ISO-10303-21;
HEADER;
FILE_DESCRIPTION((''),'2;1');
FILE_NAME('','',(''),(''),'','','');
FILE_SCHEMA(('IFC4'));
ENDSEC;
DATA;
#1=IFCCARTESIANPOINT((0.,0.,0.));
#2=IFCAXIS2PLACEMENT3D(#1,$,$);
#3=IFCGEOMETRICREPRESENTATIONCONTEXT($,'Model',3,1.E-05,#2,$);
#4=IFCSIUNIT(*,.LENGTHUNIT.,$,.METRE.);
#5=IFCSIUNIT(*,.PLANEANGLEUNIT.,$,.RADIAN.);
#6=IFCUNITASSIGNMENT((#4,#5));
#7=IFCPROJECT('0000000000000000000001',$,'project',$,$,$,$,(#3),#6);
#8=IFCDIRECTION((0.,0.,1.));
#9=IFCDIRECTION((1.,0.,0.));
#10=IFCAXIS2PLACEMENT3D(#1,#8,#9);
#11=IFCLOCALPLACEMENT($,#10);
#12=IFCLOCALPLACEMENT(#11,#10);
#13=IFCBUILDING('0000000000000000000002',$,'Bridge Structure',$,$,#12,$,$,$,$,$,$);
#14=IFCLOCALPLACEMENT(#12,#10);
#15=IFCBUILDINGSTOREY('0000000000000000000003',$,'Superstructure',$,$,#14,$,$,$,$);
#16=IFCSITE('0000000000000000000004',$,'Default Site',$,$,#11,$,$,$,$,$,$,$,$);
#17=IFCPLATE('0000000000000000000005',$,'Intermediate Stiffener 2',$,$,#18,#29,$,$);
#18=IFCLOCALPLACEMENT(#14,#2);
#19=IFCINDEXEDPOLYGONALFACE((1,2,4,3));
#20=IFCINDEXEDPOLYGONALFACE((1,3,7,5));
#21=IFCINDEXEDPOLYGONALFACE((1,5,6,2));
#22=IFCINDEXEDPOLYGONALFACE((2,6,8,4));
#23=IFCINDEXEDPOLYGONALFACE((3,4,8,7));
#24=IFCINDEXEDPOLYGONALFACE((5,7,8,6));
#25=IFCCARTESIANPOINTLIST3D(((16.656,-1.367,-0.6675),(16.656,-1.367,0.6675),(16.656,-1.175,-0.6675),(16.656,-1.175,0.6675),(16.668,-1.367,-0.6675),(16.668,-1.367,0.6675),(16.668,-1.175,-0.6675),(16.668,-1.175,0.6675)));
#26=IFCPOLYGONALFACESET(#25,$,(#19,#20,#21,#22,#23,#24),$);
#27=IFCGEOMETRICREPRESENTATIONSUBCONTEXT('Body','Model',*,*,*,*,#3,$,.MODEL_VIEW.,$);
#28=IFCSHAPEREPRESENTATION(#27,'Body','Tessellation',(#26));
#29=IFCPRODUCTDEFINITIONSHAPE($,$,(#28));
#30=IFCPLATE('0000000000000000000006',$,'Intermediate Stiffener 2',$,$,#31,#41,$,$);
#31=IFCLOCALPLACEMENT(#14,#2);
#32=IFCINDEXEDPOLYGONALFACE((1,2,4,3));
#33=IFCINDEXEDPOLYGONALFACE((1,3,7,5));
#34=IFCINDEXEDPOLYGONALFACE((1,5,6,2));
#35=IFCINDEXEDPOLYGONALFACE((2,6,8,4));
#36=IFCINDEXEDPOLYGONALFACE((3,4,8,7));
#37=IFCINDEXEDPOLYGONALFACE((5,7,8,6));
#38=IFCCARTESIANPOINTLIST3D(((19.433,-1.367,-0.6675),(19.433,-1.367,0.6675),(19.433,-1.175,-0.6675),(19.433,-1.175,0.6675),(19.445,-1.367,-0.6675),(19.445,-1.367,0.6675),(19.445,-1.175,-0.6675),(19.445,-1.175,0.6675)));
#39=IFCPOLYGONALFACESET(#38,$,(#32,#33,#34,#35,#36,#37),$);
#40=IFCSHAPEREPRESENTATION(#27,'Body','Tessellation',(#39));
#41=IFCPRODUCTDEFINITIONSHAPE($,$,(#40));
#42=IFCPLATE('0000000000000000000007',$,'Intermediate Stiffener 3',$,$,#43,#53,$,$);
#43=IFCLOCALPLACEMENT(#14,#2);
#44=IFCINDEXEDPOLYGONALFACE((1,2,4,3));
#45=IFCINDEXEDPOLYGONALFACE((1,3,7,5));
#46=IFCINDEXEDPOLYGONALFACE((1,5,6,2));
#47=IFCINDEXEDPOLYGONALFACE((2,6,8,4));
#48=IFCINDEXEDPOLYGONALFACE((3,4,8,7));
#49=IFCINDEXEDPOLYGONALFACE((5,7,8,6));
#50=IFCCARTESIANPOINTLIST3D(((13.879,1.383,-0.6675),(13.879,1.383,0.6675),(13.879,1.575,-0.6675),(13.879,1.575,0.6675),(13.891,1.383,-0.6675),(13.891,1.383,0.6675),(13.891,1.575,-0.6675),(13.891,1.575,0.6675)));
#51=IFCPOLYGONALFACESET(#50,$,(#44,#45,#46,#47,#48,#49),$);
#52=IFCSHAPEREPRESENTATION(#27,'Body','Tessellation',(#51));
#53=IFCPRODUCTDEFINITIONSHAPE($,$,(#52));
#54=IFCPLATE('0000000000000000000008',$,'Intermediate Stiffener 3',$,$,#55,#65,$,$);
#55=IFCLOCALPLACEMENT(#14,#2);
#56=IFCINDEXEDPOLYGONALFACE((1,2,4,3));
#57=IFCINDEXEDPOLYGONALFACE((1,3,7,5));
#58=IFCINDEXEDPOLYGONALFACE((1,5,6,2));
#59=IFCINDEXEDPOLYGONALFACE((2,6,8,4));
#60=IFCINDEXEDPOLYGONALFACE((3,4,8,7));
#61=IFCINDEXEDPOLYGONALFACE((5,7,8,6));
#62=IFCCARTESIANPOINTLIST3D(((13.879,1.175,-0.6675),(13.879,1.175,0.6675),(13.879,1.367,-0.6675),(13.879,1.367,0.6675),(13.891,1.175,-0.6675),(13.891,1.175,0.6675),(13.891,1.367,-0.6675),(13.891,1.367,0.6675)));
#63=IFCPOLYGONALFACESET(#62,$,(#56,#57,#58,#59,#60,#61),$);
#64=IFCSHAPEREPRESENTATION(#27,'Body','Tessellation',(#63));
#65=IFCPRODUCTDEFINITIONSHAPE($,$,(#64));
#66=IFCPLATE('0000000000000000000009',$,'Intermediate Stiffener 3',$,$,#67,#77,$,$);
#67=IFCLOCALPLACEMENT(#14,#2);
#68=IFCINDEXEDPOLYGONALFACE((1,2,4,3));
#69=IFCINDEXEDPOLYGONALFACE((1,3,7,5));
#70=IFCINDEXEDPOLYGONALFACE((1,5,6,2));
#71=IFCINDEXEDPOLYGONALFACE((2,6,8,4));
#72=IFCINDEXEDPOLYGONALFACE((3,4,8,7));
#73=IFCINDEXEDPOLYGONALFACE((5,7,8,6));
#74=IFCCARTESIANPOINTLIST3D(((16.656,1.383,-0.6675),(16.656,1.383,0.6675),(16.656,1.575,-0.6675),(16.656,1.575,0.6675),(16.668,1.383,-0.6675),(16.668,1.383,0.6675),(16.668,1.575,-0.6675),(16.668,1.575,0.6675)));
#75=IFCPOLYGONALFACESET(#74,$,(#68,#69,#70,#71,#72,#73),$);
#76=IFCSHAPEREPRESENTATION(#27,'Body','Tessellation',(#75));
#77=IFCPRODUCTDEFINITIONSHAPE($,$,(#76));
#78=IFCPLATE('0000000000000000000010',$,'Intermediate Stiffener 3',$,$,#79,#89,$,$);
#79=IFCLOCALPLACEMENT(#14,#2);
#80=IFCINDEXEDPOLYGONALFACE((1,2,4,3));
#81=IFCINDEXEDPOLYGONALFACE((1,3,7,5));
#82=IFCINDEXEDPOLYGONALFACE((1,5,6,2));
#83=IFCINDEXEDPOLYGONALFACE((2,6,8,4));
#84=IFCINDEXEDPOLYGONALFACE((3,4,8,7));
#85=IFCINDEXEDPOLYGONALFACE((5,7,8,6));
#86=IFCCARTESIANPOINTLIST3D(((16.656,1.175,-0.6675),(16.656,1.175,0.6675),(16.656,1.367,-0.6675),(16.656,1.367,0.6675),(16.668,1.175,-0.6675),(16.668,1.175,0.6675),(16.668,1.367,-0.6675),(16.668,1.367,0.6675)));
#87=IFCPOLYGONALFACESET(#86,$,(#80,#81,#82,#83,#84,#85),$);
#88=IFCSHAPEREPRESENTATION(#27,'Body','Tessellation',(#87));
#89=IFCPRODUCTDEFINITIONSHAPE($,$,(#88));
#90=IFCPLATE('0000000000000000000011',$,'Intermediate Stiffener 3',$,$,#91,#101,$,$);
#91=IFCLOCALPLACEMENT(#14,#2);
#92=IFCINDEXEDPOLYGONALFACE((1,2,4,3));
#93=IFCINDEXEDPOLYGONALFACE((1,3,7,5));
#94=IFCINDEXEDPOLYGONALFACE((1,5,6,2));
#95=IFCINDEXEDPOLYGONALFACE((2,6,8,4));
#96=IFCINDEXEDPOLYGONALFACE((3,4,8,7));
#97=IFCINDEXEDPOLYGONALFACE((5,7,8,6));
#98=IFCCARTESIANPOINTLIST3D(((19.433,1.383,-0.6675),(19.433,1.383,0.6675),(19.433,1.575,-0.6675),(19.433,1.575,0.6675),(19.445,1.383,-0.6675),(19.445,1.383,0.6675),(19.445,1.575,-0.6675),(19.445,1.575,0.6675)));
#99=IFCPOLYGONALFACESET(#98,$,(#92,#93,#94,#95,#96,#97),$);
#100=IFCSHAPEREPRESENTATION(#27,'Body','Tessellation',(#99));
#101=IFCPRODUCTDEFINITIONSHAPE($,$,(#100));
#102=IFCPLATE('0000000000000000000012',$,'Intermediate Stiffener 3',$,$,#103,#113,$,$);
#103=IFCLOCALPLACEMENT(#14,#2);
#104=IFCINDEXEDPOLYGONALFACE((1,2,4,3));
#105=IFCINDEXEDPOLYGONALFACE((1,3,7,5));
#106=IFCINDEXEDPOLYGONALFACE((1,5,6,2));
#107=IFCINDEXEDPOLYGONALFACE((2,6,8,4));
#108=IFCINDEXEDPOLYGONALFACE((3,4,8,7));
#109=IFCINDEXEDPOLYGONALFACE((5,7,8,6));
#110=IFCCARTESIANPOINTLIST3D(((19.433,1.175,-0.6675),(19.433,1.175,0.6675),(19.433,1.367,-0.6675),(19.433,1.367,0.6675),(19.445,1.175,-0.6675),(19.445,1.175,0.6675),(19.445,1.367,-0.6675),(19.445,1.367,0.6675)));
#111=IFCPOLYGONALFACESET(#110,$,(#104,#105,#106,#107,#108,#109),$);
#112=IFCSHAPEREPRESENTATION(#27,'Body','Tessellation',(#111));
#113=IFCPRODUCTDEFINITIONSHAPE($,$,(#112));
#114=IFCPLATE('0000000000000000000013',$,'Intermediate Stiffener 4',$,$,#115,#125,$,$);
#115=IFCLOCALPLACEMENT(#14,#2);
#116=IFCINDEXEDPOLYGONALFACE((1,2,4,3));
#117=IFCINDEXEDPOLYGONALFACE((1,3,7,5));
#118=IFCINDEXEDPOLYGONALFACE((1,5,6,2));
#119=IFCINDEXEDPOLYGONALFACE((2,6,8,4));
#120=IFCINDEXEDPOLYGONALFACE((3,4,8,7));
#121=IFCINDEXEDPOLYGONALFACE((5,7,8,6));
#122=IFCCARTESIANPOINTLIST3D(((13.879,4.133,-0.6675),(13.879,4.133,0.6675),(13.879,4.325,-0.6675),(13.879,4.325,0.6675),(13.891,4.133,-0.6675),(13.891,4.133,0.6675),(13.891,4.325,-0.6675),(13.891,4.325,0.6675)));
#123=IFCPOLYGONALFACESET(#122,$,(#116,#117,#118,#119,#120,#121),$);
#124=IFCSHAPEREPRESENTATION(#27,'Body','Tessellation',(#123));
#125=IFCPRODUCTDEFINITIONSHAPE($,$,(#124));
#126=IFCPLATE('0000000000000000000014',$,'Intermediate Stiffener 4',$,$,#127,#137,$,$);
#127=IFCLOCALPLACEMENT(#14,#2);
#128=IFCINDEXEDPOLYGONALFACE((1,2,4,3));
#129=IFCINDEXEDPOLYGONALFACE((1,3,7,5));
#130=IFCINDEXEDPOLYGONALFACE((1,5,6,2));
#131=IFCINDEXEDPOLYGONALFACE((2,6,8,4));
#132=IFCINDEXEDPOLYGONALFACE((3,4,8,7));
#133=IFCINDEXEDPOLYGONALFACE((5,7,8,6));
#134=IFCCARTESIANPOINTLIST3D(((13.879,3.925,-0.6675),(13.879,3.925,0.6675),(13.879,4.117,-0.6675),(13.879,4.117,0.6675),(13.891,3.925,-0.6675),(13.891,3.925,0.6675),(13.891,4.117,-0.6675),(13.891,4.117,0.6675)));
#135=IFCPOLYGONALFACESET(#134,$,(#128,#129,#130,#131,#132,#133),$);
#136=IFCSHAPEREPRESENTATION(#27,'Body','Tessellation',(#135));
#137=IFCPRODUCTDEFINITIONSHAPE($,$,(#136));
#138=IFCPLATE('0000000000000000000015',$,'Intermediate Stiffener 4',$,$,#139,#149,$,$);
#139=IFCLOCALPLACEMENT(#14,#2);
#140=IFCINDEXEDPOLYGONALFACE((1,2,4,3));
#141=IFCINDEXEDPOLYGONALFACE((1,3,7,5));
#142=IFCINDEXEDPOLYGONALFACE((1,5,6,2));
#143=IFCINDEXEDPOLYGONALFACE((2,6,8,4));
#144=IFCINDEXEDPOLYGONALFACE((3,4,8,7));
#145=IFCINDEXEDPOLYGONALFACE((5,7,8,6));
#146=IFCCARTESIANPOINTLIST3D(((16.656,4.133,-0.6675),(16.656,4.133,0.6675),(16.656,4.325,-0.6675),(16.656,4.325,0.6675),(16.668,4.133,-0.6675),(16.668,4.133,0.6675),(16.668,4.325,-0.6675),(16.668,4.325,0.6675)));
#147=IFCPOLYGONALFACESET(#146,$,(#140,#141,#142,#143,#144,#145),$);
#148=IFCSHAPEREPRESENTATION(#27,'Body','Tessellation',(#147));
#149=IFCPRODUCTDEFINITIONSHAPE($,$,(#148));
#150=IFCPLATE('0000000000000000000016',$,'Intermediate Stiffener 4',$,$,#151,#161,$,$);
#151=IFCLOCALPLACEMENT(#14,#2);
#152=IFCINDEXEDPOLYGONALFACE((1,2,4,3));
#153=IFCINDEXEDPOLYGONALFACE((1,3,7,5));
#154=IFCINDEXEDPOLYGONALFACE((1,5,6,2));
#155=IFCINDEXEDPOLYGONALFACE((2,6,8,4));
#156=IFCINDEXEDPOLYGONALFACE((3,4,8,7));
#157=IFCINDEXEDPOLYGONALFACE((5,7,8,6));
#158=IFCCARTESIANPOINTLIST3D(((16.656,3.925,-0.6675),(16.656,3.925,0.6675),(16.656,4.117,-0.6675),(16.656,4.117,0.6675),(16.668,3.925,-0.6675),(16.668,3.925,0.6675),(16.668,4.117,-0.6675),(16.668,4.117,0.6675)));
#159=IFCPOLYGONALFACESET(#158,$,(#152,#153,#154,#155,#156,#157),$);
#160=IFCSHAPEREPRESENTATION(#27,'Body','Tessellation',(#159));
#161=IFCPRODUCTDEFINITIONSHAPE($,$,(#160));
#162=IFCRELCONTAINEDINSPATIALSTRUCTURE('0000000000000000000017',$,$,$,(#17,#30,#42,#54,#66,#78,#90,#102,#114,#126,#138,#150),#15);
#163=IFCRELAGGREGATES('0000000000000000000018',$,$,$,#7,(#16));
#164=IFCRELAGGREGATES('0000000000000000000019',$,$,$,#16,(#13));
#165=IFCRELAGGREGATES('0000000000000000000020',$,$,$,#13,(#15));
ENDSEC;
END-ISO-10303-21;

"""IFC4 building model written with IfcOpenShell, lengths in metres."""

from ifc_helpers import new_model, si_unit, frame, origin, origin_with_axes, origin_2d_with_axis, place, context, subcontext, project, spatial, rectangle, extrude, element, save


model = new_model("IFC4")

# Units and contexts
model_context = context("Model", 3, precision=1e-05, world=origin())
body_context = subcontext(model_context, "Body", "Model", "MODEL_VIEW")
ifc_project = project(units=[si_unit("LENGTHUNIT", "METRE"), si_unit("PLANEANGLEUNIT", "RADIAN")], contexts=[model_context])

# Site, building, storey
site_placement = place(None, origin_with_axes())
site = spatial("IfcSite", under=ifc_project, at=site_placement, Name="Default Site")
building_placement = place(site_placement, origin_with_axes())
building = spatial("IfcBuilding", under=site, at=building_placement, Name="Bridge Structure")
storey_placement = place(building_placement, origin_with_axes())
storey = spatial("IfcBuildingStorey", under=building, at=storey_placement, Name="Superstructure")

# Plates
for number, where, z_axis, x_axis, name in (
    (1, (16.662, -1.271, -0.6675), (0.0, 0.0, 1.0), (1.0, 0.0, 0.0), "Intermediate Stiffener 2"),
    (2, (19.439, -1.271, -0.6675), (0.0, 0.0, 1.0), (1.0, 0.0, 0.0), "Intermediate Stiffener 2"),
    (3, (13.885, 1.479, -0.6675), (0.0, 0.0, 1.0), (1.0, 0.0, 0.0), "Intermediate Stiffener 3"),
    (4, (13.885, 1.271, -0.6675), (0.0, 0.0, 1.0), (1.0, 0.0, 0.0), "Intermediate Stiffener 3"),
    (5, (16.662, 1.479, -0.6675), (0.0, 0.0, 1.0), (1.0, 0.0, 0.0), "Intermediate Stiffener 3"),
    (6, (16.662, 1.271, -0.6675), (0.0, 0.0, 1.0), (1.0, 0.0, 0.0), "Intermediate Stiffener 3"),
    (7, (19.439, 1.479, -0.6675), (0.0, 0.0, 1.0), (1.0, 0.0, 0.0), "Intermediate Stiffener 3"),
    (8, (19.439, 1.271, -0.6675), (0.0, 0.0, 1.0), (1.0, 0.0, 0.0), "Intermediate Stiffener 3"),
    (9, (13.885, 4.229, -0.6675), (0.0, 0.0, 1.0), (1.0, 0.0, 0.0), "Intermediate Stiffener 4"),
    (10, (13.885, 4.021, -0.6675), (0.0, 0.0, 1.0), (1.0, 0.0, 0.0), "Intermediate Stiffener 4"),
    (11, (16.662, 4.229, -0.6675), (0.0, 0.0, 1.0), (1.0, 0.0, 0.0), "Intermediate Stiffener 4"),
    (12, (16.662, 4.021, -0.6675), (0.0, 0.0, 1.0), (1.0, 0.0, 0.0), "Intermediate Stiffener 4"),
):
    element("IfcPlate", number, at=place(storey_placement, frame(where, z_axis=z_axis, x_axis=x_axis)), inside=storey, Name=name, context=body_context, shape_type="SweptSolid", body=[
        extrude(rectangle(XDim=0.012, YDim=0.192, at=origin_2d_with_axis()), origin_with_axes(), (0.0, 0.0, 1.0), 1.335),
    ])

save(model, "model.ifc")
